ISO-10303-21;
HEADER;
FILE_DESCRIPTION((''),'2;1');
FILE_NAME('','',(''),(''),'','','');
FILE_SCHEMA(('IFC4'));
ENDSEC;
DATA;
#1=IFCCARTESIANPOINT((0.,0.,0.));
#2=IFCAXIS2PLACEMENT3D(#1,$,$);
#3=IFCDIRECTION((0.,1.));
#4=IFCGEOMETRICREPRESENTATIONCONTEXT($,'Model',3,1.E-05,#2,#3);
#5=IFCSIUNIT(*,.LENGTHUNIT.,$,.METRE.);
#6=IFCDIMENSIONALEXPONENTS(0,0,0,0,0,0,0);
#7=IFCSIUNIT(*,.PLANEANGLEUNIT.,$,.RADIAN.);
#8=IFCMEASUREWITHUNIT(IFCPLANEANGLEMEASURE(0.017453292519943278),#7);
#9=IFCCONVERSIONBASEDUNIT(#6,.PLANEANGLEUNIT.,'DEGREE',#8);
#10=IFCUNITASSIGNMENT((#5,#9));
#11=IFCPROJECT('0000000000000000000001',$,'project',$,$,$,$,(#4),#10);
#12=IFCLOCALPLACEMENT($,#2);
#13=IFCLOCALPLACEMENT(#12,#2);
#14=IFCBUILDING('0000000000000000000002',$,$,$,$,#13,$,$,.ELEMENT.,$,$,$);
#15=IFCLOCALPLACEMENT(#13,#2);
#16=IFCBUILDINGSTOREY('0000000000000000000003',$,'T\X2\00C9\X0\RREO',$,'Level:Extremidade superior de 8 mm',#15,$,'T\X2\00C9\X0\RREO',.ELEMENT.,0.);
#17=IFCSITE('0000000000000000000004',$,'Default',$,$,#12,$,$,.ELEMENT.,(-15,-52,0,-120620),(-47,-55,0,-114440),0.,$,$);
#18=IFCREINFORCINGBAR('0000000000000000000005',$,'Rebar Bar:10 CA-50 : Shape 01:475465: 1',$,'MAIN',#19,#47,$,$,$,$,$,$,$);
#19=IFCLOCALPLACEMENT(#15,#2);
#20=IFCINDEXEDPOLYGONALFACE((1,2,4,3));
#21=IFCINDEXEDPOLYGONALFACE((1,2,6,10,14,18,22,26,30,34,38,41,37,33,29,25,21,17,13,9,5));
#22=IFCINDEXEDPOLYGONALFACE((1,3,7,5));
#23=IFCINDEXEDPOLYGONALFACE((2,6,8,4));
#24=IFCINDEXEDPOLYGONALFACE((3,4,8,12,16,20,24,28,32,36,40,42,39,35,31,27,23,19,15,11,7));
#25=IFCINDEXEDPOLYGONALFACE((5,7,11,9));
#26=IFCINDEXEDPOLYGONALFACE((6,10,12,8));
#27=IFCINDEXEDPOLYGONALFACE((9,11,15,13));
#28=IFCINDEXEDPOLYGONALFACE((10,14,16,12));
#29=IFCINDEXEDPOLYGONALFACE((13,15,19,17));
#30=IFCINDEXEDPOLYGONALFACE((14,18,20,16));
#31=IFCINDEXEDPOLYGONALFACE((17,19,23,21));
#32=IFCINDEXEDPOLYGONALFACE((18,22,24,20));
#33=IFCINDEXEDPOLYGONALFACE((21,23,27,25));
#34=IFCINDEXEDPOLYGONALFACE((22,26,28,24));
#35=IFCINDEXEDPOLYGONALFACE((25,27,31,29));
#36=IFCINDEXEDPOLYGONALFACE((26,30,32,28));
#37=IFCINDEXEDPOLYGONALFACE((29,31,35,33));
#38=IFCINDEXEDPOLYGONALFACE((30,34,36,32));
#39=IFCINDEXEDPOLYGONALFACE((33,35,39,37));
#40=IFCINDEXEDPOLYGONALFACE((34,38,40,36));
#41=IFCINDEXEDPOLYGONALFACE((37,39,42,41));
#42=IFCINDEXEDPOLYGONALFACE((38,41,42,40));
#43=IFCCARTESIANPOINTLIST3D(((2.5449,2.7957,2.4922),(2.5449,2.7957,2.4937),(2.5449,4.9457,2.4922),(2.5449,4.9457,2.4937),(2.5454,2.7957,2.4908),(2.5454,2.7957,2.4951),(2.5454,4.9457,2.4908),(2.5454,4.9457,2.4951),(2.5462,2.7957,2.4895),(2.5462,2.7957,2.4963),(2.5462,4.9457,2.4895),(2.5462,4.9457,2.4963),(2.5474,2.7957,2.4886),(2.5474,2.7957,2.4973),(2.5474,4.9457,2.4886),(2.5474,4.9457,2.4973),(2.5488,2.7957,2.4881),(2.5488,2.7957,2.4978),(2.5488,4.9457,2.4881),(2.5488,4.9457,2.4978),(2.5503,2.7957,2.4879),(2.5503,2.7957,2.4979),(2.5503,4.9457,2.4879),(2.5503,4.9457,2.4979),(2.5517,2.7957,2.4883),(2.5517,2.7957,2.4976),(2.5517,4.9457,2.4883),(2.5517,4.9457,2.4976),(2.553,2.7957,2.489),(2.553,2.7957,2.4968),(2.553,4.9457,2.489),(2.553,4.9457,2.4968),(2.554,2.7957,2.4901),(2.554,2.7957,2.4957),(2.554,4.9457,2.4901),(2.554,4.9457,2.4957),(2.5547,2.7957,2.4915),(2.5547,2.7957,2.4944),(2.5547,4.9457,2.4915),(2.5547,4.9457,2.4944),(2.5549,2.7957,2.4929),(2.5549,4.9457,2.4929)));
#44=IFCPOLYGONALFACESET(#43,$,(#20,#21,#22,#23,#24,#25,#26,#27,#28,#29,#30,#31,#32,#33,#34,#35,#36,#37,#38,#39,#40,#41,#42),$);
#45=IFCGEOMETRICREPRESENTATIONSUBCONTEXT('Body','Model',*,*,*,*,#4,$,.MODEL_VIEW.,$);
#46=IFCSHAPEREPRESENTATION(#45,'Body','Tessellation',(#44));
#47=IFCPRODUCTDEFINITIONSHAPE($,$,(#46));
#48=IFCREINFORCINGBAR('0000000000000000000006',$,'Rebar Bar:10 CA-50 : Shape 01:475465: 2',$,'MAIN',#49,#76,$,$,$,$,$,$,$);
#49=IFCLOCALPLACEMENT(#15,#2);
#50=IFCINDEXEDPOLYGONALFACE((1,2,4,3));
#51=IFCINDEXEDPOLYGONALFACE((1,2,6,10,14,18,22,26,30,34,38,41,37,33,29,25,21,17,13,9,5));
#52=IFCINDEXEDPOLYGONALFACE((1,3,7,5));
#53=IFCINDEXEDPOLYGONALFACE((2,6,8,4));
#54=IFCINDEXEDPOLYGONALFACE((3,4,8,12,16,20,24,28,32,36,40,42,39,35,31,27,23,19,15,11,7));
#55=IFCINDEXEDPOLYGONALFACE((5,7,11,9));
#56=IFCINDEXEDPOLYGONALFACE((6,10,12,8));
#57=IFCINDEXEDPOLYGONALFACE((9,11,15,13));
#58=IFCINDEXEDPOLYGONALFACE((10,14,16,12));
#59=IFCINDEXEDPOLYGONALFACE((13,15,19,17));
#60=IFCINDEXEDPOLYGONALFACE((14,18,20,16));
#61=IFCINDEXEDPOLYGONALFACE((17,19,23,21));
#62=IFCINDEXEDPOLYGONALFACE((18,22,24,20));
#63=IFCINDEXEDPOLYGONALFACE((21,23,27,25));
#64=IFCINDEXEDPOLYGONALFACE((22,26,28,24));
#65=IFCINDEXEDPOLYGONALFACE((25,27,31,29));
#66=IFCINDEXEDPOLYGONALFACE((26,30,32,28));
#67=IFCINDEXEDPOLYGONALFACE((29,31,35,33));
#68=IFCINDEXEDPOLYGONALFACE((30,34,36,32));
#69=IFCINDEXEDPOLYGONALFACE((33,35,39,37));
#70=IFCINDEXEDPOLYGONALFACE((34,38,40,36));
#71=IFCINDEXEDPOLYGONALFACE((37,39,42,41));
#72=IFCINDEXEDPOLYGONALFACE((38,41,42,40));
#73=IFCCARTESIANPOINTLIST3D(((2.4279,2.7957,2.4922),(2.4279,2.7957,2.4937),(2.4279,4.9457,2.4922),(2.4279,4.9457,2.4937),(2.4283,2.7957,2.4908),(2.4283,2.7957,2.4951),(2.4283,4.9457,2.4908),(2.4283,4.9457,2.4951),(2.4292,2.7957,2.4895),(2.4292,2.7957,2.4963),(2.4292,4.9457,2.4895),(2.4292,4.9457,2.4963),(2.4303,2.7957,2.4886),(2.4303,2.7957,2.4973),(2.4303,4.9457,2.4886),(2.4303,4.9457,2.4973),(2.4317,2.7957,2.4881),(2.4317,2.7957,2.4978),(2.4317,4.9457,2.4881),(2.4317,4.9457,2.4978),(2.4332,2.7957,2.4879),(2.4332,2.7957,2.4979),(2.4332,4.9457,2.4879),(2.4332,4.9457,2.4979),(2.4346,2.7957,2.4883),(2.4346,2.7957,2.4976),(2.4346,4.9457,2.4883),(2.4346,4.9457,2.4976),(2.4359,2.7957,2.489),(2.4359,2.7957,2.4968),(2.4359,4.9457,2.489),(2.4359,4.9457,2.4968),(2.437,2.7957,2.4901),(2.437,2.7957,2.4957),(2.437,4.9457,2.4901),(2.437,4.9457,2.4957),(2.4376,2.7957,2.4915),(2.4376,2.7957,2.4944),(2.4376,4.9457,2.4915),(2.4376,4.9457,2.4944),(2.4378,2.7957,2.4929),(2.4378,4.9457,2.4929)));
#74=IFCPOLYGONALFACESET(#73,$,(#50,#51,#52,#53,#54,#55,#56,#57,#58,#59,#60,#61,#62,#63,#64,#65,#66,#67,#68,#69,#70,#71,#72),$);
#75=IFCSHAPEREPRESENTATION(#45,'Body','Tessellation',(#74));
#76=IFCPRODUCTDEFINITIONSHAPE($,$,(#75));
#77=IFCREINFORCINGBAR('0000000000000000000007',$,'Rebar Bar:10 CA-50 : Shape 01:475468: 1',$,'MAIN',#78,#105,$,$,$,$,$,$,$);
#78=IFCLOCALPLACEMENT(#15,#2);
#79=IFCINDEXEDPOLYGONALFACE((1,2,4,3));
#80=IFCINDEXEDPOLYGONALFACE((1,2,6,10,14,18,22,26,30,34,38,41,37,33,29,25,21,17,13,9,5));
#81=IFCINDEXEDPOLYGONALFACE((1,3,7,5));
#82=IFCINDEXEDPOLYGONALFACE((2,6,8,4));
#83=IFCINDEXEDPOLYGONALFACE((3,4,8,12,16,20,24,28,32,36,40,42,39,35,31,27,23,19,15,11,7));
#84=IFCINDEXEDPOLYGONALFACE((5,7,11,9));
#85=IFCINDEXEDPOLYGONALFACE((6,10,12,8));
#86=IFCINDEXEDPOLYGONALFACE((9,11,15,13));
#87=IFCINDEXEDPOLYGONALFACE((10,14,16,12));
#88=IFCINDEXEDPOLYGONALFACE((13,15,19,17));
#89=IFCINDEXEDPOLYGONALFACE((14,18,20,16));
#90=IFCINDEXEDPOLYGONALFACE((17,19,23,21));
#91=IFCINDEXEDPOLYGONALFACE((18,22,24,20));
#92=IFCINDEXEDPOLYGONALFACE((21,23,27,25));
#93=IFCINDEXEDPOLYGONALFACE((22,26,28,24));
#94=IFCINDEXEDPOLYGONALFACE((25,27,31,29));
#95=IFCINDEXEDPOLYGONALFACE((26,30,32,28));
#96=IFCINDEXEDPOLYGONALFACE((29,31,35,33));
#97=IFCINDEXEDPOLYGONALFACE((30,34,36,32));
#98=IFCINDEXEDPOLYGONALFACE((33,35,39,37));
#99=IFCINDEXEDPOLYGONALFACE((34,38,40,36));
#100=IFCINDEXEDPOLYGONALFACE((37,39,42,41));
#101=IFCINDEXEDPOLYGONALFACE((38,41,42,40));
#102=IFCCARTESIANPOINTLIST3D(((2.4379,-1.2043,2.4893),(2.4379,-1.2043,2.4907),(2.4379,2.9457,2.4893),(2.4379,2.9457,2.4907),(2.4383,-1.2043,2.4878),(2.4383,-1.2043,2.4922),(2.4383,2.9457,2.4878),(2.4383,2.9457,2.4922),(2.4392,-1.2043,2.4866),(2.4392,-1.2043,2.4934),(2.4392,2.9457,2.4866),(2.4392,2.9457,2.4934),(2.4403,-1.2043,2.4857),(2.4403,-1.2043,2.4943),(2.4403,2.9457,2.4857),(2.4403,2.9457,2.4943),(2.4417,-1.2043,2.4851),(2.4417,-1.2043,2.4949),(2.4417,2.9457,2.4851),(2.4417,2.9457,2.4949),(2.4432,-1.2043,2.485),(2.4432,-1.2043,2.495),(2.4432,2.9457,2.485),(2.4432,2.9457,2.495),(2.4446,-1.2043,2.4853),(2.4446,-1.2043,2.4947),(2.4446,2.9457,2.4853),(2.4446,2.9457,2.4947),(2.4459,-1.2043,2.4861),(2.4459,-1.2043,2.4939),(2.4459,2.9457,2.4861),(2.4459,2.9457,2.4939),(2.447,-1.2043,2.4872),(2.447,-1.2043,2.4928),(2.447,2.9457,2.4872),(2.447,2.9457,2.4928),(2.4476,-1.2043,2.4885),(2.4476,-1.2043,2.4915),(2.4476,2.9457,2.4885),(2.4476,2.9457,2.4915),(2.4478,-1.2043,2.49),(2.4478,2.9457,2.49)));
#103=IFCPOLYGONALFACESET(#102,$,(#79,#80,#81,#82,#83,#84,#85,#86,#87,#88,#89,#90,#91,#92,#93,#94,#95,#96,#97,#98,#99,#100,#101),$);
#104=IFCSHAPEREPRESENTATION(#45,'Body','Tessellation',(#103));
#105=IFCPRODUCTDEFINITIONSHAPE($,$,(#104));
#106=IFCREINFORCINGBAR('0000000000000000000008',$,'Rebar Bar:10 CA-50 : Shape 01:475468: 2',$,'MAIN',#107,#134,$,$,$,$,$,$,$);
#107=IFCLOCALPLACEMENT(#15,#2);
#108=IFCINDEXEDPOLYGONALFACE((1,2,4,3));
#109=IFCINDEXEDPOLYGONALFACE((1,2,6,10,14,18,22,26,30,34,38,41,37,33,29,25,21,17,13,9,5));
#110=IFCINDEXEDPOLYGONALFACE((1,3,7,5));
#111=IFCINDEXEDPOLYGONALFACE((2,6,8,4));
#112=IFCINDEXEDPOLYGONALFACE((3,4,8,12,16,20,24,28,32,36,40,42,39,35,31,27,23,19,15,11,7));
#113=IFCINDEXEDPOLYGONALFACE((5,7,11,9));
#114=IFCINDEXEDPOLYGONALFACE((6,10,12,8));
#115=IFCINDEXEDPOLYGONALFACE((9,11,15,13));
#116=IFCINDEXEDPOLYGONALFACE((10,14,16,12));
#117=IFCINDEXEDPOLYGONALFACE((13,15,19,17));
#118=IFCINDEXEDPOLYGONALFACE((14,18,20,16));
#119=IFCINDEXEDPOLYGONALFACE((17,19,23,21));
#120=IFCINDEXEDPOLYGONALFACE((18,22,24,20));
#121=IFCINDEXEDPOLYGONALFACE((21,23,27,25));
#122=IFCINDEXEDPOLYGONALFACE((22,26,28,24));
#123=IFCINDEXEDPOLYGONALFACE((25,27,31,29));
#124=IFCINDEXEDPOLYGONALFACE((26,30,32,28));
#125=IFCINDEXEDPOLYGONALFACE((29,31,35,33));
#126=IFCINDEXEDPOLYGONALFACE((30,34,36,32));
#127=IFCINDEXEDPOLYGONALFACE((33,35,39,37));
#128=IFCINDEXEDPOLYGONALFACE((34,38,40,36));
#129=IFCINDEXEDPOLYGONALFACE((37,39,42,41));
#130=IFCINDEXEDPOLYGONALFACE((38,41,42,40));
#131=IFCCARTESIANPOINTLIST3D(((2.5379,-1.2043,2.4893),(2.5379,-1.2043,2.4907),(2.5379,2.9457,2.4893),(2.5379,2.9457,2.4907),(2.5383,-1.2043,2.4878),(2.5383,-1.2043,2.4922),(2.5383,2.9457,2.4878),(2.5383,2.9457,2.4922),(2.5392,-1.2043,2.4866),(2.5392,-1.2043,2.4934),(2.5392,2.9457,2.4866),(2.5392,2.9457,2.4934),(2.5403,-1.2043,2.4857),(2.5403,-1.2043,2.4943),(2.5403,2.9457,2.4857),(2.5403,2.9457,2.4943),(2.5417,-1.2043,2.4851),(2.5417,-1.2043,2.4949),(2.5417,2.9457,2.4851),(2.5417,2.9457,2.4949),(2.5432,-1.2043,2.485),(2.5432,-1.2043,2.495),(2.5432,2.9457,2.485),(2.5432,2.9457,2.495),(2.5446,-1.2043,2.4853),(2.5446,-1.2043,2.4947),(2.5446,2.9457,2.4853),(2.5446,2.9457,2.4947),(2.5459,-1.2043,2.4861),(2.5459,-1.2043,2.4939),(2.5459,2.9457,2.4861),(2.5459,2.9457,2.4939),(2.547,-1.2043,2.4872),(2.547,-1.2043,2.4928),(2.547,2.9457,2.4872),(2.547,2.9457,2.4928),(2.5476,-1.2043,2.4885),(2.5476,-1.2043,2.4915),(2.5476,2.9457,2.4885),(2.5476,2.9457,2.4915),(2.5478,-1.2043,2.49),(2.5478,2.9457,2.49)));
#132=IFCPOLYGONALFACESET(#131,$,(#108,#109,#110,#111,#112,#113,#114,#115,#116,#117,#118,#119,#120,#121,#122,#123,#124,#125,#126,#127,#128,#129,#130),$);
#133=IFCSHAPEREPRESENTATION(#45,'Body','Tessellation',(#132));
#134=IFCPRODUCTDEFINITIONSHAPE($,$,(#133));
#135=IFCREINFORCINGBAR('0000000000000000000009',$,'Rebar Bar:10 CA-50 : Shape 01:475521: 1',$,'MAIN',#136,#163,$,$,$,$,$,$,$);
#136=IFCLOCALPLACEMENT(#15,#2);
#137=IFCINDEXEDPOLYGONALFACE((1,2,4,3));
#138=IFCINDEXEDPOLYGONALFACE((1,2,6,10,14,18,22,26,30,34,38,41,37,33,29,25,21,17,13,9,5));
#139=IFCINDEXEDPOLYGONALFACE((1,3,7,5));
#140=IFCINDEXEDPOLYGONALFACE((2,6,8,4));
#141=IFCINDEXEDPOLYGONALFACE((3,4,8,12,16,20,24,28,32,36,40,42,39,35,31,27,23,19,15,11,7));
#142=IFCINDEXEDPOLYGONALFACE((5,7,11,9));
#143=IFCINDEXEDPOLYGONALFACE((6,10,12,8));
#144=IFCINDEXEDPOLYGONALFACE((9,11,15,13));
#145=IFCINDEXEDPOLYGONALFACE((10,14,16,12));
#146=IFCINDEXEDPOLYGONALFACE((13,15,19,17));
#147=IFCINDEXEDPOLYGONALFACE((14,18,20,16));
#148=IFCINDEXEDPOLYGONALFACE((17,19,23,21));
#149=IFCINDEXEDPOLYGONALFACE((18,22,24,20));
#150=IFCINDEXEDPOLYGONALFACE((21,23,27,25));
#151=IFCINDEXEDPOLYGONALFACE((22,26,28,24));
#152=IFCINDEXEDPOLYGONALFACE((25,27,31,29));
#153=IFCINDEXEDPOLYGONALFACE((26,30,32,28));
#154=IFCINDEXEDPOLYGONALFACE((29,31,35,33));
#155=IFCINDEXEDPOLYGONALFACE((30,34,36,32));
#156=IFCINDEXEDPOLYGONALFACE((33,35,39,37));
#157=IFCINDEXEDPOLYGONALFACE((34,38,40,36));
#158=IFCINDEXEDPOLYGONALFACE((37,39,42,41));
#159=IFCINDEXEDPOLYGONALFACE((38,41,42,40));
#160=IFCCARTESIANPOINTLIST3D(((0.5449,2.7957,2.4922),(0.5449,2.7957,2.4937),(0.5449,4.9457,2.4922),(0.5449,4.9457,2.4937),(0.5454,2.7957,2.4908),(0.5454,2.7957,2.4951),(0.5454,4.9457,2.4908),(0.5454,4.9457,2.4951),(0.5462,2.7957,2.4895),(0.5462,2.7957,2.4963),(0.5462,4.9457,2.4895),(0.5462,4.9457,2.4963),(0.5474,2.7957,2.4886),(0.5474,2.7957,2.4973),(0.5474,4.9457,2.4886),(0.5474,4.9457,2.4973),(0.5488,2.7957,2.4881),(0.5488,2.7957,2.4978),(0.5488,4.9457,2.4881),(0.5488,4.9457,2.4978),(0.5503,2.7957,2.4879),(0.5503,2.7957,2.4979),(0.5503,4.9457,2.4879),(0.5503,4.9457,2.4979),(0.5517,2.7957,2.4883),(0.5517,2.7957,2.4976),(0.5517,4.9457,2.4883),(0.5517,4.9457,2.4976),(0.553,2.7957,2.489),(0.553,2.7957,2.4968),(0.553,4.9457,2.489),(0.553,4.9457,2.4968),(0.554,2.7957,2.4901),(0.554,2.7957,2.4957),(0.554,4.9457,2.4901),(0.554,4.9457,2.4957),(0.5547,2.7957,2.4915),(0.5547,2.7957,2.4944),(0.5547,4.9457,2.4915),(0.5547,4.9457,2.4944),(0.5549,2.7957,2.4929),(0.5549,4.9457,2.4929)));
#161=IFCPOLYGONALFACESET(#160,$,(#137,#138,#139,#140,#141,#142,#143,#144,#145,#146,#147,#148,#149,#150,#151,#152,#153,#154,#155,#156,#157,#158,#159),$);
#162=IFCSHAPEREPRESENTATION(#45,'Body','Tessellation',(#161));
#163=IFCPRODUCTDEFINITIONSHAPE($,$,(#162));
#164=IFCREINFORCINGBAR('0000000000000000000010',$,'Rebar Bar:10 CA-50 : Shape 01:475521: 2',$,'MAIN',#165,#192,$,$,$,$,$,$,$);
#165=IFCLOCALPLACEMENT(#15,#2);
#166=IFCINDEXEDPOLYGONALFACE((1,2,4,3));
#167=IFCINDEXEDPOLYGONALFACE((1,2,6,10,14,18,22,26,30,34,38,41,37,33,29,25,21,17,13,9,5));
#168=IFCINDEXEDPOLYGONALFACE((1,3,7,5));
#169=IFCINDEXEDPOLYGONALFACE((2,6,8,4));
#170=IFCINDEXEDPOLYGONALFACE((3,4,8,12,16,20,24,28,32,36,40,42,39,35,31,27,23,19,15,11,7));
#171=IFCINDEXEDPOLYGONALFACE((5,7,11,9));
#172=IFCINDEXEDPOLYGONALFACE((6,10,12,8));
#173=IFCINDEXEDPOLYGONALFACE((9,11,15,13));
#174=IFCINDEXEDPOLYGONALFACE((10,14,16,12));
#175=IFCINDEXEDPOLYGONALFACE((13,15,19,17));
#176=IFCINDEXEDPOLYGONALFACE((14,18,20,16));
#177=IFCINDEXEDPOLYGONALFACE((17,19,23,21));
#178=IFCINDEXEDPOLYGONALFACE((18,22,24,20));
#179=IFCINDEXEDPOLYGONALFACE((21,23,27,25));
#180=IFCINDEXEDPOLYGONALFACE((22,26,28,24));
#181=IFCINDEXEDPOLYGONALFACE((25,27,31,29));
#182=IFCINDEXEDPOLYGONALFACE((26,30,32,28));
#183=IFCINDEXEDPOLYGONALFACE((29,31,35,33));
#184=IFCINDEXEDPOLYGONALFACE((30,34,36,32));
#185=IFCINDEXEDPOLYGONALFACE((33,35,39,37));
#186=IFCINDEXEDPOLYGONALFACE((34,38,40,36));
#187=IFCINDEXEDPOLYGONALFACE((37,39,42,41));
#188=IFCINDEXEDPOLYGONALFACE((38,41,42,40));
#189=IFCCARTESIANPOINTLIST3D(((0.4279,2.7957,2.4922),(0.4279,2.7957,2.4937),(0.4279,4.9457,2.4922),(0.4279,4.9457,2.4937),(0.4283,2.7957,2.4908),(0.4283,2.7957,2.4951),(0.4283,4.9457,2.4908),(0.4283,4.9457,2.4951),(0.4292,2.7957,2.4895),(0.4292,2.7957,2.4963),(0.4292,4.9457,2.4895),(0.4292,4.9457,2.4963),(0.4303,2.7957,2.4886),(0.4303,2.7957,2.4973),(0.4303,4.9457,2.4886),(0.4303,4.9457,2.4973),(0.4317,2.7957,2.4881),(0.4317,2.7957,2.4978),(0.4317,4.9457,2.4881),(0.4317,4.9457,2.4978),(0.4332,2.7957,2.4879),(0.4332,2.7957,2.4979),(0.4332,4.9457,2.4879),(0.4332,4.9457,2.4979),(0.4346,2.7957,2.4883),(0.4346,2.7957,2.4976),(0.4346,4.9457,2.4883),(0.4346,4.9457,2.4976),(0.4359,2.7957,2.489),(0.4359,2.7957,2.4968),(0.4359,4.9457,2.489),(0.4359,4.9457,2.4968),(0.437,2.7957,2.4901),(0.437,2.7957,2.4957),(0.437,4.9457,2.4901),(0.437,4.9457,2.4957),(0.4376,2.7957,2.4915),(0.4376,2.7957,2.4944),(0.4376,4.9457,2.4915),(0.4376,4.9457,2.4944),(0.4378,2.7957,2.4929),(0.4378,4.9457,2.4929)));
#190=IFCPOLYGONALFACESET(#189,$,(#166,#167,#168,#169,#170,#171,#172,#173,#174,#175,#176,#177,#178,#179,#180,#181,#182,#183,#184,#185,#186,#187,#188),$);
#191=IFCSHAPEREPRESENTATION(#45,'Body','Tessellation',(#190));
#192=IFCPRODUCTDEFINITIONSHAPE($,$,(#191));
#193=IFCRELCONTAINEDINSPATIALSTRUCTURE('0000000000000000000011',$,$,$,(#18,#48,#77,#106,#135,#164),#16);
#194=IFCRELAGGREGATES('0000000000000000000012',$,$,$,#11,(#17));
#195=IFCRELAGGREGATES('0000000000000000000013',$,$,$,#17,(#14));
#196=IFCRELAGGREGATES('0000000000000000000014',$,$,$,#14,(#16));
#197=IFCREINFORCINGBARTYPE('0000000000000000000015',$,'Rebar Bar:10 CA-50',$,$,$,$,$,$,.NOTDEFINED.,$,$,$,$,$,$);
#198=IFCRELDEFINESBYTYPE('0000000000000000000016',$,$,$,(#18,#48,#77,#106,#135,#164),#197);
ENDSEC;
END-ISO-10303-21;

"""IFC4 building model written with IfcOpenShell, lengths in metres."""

from ifc_helpers import new_model, entity, si_unit, converted_unit, direction, origin, place, context, subcontext, project, spatial, type_object, element, save


model = new_model("IFC4")

# Units and contexts
model_context = context("Model", 3, precision=1e-05, world=origin(), true_north=direction((0.0, 1.0)))
body_context = subcontext(model_context, "Body", "Model", "MODEL_VIEW")
ifc_project = project(units=[si_unit("LENGTHUNIT", "METRE"), converted_unit("PLANEANGLEUNIT", "DEGREE", entity("IfcPlaneAngleMeasure", 0.017453292519943278), si_unit("PLANEANGLEUNIT", "RADIAN"), dimensions=[0, 0, 0, 0, 0, 0, 0])], contexts=[model_context])

# Site, building, storey
site_placement = place(None, origin())
site = spatial("IfcSite", under=ifc_project, at=site_placement, Name="Default", CompositionType="ELEMENT", RefLatitude=(-15, -52, 0, -120620), RefLongitude=(-47, -55, 0, -114440), RefElevation=0.0)
building_placement = place(site_placement, origin())
building = spatial("IfcBuilding", under=site, at=building_placement, CompositionType="ELEMENT")
storey_placement = place(building_placement, origin())
storey = spatial("IfcBuildingStorey", under=building, at=storey_placement, Name="TÉRREO", ObjectType="Level:Extremidade superior de 8 mm", LongName="TÉRREO", CompositionType="ELEMENT", Elevation=0.0)

# Reinforcing bars
reinforcing_bar_type = type_object("IfcReinforcingBarType", Name="Rebar Bar:10 CA-50", PredefinedType="NOTDEFINED")
reinforcing_bar_1_placement = place(storey_placement, origin())
element("IfcReinforcingBar", 1, at=reinforcing_bar_1_placement, inside=storey, type_object=reinforcing_bar_type, Name="Rebar Bar:10 CA-50 : Shape 01:475465: 1", ObjectType="MAIN", context=body_context, shape_type="AdvancedSweptSolid", body=[
    entity("IfcSweptDiskSolid", entity("IfcIndexedPolyCurve", entity("IfcCartesianPointList3D", [[2.5499, 2.7957, 2.4929], [2.5499, 4.9457, 2.4929]]), None, False), 0.005, None, 0.0, 1.0),
])
reinforcing_bar_2_placement = place(storey_placement, origin())
element("IfcReinforcingBar", 2, at=reinforcing_bar_2_placement, inside=storey, type_object=reinforcing_bar_type, Name="Rebar Bar:10 CA-50 : Shape 01:475465: 2", ObjectType="MAIN", context=body_context, shape_type="AdvancedSweptSolid", body=[
    entity("IfcSweptDiskSolid", entity("IfcIndexedPolyCurve", entity("IfcCartesianPointList3D", [[2.4328, 2.7957, 2.4929], [2.4328, 4.9457, 2.4929]]), None, False), 0.005, None, 0.0, 1.0),
])
reinforcing_bar_3_placement = place(storey_placement, origin())
element("IfcReinforcingBar", 3, at=reinforcing_bar_3_placement, inside=storey, type_object=reinforcing_bar_type, Name="Rebar Bar:10 CA-50 : Shape 01:475468: 1", ObjectType="MAIN", context=body_context, shape_type="AdvancedSweptSolid", body=[
    entity("IfcSweptDiskSolid", entity("IfcIndexedPolyCurve", entity("IfcCartesianPointList3D", [[2.4428, -1.2043, 2.49], [2.4428, 2.9457, 2.49]]), None, False), 0.005, None, 0.0, 1.0),
])
reinforcing_bar_4_placement = place(storey_placement, origin())
element("IfcReinforcingBar", 4, at=reinforcing_bar_4_placement, inside=storey, type_object=reinforcing_bar_type, Name="Rebar Bar:10 CA-50 : Shape 01:475468: 2", ObjectType="MAIN", context=body_context, shape_type="AdvancedSweptSolid", body=[
    entity("IfcSweptDiskSolid", entity("IfcIndexedPolyCurve", entity("IfcCartesianPointList3D", [[2.5428, -1.2043, 2.49], [2.5428, 2.9457, 2.49]]), None, False), 0.005, None, 0.0, 1.0),
])
reinforcing_bar_5_placement = place(storey_placement, origin())
element("IfcReinforcingBar", 5, at=reinforcing_bar_5_placement, inside=storey, type_object=reinforcing_bar_type, Name="Rebar Bar:10 CA-50 : Shape 01:475521: 1", ObjectType="MAIN", context=body_context, shape_type="AdvancedSweptSolid", body=[
    entity("IfcSweptDiskSolid", entity("IfcIndexedPolyCurve", entity("IfcCartesianPointList3D", [[0.5499, 2.7957, 2.4929], [0.5499, 4.9457, 2.4929]]), None, False), 0.005, None, 0.0, 1.0),
])
reinforcing_bar_6_placement = place(storey_placement, origin())
element("IfcReinforcingBar", 6, at=reinforcing_bar_6_placement, inside=storey, type_object=reinforcing_bar_type, Name="Rebar Bar:10 CA-50 : Shape 01:475521: 2", ObjectType="MAIN", context=body_context, shape_type="AdvancedSweptSolid", body=[
    entity("IfcSweptDiskSolid", entity("IfcIndexedPolyCurve", entity("IfcCartesianPointList3D", [[0.4328, 2.7957, 2.4929], [0.4328, 4.9457, 2.4929]]), None, False), 0.005, None, 0.0, 1.0),
])

save(model, "model.ifc")
